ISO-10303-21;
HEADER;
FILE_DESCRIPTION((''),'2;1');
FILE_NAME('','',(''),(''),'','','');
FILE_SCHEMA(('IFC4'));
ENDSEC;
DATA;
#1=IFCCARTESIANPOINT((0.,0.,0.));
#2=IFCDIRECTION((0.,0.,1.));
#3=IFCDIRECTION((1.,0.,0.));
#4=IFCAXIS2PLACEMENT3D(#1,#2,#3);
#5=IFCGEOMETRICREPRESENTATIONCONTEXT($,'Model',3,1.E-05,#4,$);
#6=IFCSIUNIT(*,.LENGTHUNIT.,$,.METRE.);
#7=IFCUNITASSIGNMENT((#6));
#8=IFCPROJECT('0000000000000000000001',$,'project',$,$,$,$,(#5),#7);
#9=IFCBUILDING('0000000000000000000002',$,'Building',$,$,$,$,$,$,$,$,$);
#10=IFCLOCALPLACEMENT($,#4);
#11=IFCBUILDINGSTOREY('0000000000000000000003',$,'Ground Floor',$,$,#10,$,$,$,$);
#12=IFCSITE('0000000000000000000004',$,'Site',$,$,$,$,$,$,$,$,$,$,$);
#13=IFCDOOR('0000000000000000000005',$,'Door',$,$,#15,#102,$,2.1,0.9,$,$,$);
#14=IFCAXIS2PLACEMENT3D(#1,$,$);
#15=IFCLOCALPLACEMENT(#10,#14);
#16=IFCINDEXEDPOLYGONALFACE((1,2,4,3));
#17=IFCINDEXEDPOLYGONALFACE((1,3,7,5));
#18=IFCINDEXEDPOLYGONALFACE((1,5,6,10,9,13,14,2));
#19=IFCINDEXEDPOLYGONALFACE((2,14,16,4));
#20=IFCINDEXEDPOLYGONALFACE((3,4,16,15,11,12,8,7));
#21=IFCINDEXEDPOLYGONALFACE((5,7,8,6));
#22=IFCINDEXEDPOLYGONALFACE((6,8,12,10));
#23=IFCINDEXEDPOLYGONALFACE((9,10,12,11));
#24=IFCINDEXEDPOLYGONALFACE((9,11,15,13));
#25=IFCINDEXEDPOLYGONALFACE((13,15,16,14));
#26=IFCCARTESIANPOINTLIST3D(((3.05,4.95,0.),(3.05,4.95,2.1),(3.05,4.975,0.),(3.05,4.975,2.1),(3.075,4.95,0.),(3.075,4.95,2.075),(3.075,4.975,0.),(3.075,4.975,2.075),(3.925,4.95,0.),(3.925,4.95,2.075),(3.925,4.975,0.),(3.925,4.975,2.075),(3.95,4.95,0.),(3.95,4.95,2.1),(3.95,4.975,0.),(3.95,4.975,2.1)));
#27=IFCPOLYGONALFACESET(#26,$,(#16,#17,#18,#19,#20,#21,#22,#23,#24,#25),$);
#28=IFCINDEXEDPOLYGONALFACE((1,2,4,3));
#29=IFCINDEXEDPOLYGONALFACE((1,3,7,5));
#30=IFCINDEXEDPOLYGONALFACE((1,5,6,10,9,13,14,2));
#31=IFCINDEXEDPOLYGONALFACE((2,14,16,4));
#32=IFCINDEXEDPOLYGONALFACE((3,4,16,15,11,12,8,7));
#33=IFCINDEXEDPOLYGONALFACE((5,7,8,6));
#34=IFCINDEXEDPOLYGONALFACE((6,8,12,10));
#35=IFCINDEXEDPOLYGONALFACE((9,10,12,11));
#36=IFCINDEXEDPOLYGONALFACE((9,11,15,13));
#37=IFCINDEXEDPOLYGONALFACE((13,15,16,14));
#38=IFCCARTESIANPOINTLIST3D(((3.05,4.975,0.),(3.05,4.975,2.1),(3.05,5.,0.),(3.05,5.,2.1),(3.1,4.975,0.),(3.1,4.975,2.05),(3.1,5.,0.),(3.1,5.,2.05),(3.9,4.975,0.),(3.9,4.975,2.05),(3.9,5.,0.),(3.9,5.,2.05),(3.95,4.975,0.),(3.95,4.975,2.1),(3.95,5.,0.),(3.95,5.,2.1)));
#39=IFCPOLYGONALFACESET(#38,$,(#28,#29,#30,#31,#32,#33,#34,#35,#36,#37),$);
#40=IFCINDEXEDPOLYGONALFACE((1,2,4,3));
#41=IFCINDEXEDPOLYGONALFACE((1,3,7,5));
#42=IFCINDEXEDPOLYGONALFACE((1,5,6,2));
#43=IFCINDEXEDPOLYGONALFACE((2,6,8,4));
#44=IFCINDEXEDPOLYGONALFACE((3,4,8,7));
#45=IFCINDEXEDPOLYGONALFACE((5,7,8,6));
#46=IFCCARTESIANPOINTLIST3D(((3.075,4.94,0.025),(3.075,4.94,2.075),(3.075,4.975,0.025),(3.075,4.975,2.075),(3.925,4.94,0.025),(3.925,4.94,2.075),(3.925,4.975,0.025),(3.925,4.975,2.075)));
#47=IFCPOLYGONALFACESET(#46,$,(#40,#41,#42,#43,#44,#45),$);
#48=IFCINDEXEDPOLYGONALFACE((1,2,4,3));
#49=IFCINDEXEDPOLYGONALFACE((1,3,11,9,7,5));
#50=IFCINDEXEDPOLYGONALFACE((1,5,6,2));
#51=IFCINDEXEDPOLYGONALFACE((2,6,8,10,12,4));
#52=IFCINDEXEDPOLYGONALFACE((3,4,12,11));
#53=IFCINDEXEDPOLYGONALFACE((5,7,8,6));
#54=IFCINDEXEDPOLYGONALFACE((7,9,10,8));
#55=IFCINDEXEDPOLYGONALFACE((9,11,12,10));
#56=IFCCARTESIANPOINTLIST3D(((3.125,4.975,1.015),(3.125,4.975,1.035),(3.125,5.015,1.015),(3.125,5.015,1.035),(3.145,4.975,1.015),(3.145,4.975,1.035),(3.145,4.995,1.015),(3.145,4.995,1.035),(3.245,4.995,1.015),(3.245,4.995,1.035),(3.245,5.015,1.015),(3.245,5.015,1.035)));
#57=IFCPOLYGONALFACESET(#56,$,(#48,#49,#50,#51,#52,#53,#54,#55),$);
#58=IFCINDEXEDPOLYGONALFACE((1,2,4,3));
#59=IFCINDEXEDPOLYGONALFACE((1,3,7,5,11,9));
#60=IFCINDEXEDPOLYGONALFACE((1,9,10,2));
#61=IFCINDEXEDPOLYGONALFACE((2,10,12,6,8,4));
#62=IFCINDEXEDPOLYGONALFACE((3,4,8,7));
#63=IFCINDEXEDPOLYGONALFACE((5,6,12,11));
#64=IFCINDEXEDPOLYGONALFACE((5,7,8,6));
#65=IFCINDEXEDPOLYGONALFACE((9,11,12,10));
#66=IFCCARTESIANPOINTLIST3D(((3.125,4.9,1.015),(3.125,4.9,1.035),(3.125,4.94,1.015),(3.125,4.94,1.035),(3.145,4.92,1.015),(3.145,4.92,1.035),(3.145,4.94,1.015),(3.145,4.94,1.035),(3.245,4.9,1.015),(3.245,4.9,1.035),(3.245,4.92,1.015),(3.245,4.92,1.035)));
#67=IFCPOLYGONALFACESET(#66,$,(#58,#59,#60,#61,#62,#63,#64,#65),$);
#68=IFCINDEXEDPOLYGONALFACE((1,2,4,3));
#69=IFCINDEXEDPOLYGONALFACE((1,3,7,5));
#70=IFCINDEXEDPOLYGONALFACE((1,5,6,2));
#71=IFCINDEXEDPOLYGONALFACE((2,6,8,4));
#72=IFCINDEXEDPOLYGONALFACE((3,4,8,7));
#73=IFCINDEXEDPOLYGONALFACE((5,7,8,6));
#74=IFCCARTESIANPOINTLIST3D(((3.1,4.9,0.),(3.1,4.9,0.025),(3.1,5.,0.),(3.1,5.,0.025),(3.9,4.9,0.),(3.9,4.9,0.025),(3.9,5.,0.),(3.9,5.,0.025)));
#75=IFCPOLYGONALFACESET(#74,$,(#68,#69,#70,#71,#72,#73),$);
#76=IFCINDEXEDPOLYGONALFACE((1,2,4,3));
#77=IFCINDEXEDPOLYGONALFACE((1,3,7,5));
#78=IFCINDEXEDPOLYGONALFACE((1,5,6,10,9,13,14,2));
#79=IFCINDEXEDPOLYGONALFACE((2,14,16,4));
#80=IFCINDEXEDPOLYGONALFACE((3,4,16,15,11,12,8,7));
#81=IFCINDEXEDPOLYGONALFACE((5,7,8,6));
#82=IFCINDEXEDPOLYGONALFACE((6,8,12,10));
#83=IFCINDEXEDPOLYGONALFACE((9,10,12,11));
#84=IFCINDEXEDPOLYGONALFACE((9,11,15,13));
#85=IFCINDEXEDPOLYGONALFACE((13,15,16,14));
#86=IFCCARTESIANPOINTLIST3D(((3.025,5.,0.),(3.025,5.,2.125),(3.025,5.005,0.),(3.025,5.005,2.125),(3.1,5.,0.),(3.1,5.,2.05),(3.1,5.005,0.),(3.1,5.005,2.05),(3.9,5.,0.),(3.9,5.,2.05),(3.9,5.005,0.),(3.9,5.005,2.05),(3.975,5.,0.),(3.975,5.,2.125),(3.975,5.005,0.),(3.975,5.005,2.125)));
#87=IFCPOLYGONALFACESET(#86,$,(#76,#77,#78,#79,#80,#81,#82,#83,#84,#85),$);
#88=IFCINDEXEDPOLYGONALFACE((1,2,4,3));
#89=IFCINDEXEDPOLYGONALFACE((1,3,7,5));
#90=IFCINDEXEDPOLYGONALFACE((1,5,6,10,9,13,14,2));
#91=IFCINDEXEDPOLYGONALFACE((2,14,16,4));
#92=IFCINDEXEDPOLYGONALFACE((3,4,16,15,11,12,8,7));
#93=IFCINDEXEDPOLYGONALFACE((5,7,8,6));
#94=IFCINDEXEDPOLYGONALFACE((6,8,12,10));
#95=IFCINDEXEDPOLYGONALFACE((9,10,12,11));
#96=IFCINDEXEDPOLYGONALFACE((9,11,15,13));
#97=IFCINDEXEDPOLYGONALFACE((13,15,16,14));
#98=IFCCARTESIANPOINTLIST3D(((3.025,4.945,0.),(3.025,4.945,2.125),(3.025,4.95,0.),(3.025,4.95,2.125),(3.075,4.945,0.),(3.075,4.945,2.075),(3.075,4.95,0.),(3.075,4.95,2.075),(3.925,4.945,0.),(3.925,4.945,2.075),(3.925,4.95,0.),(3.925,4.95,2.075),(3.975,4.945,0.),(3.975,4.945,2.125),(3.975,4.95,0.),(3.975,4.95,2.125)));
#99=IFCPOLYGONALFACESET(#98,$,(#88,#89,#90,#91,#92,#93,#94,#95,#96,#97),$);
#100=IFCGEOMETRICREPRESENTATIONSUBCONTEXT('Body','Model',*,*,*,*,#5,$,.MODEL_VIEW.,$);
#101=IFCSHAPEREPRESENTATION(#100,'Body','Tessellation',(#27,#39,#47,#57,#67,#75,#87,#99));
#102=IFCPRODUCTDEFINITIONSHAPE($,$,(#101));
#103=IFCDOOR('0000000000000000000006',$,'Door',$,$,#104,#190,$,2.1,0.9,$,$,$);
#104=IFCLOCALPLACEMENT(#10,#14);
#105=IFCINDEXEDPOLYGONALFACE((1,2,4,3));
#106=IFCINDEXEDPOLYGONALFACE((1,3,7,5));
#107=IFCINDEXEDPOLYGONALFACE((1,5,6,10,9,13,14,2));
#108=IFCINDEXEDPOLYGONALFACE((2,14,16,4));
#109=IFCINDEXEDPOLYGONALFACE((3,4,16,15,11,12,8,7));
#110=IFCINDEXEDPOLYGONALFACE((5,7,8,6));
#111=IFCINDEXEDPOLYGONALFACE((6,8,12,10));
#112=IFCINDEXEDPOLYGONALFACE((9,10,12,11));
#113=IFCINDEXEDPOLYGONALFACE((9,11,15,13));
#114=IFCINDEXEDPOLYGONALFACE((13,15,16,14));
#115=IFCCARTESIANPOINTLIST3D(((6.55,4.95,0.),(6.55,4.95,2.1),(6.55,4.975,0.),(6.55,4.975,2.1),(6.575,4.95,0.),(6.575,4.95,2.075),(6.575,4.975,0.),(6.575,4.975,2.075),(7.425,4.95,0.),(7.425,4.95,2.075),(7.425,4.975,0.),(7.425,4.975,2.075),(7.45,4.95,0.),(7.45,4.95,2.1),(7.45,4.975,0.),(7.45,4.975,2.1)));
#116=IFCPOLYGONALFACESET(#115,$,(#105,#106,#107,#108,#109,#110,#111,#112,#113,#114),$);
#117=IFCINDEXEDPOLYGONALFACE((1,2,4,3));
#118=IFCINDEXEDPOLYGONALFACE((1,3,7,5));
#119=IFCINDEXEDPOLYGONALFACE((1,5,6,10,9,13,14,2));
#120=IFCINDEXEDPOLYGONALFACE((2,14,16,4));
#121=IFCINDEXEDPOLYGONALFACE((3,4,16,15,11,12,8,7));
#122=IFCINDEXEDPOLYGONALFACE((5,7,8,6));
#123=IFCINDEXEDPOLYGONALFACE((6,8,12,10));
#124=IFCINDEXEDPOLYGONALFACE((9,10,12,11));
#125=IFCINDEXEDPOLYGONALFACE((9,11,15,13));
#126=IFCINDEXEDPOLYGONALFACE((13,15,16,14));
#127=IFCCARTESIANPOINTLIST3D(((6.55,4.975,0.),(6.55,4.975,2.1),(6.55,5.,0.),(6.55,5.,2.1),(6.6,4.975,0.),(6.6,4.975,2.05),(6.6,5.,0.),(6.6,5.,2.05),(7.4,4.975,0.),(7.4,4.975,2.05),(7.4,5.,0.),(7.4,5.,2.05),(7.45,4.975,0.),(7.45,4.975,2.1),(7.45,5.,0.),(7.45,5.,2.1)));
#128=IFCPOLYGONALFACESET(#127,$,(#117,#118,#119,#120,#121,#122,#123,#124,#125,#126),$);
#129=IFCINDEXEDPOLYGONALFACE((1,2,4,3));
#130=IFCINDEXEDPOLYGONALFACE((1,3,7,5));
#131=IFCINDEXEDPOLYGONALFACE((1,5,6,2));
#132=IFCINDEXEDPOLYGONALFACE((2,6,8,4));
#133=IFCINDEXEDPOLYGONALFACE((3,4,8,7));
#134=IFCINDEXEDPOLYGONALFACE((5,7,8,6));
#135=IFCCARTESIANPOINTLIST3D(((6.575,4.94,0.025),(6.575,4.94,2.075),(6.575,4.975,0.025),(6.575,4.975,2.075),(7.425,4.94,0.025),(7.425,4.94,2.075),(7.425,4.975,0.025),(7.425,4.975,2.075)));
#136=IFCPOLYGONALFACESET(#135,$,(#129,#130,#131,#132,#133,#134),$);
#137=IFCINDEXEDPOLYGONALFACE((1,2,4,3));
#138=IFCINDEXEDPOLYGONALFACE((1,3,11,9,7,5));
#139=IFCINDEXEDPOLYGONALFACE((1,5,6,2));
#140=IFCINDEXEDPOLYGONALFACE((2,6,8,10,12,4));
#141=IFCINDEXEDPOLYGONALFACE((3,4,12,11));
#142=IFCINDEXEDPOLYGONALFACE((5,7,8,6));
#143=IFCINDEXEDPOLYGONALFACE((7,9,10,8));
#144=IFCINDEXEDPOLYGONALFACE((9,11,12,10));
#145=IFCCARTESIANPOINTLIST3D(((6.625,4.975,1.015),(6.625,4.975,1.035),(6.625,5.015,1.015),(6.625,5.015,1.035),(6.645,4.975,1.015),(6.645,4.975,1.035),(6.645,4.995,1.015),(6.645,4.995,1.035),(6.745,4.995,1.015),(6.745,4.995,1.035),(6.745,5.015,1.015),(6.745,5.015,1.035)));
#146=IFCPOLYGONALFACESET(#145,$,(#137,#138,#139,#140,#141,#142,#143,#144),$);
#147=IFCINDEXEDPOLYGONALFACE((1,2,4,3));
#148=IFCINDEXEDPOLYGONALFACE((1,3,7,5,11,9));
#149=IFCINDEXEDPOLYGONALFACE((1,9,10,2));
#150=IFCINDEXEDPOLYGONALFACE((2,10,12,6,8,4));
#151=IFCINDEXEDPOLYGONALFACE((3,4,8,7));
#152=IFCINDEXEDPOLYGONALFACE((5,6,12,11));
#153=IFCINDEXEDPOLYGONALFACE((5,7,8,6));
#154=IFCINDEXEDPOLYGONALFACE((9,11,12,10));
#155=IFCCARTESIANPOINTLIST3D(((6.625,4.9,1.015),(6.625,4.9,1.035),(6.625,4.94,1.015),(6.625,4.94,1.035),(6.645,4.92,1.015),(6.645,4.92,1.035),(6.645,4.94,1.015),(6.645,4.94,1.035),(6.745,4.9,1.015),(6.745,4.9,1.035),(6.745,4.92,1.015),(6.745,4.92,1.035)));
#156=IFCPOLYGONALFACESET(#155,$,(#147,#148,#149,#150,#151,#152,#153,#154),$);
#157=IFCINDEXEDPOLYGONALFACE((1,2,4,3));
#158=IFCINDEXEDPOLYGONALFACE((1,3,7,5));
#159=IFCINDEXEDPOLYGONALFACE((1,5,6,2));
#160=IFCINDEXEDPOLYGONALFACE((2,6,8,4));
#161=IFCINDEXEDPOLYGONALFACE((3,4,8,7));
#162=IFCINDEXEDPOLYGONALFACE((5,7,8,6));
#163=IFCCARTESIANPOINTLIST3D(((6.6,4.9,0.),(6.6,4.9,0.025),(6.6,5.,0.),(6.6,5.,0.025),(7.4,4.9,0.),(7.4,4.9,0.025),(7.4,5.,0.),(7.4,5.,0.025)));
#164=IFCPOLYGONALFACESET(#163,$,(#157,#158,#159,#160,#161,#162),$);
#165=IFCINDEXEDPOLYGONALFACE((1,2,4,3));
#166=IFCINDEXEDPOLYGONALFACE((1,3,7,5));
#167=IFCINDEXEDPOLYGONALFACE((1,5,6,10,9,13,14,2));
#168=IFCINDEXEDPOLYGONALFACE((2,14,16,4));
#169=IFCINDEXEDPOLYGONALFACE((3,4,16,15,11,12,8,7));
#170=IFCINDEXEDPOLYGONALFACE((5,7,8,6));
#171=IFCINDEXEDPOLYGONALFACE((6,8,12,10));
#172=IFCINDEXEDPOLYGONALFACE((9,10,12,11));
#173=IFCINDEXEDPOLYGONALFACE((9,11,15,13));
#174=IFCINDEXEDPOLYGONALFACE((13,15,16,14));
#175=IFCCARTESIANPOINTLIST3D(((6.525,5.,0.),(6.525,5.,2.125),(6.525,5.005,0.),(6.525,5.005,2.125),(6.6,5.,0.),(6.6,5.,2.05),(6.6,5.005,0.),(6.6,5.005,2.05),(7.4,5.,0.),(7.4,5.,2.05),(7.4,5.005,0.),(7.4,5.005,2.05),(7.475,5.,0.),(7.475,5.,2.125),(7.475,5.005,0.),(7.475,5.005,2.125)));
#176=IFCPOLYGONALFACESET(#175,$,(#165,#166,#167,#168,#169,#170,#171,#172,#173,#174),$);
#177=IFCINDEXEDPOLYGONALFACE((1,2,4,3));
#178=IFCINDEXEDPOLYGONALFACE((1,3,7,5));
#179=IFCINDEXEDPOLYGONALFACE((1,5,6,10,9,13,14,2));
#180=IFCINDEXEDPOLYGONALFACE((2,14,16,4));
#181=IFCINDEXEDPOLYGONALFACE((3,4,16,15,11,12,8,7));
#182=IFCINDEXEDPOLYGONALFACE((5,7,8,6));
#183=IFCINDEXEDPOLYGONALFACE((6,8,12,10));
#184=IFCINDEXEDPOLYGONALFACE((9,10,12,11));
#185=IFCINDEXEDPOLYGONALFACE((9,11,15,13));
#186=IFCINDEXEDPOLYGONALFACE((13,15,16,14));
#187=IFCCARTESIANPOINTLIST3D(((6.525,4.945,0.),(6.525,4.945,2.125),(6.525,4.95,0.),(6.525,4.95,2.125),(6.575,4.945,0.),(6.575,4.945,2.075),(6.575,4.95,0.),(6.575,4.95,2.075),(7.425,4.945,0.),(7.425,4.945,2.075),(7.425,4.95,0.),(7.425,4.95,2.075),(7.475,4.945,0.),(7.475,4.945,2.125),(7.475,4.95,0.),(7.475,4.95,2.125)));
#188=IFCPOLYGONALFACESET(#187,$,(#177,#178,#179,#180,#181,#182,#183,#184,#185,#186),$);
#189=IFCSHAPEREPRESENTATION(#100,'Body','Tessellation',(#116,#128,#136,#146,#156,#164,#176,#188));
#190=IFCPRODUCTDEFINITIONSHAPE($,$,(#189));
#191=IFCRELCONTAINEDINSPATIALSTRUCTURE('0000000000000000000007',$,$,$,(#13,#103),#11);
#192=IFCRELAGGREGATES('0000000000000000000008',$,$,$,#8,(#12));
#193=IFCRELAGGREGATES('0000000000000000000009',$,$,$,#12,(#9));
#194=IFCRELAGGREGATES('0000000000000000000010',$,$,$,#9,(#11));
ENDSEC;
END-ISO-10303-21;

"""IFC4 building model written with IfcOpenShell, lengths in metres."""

from ifc_helpers import new_model, si_unit, frame, origin_with_axes, place, context, subcontext, project, spatial, line, indexed_curve, outline, extrude, element, save


model = new_model("IFC4")

# Units and contexts
model_context = context("Model", 3, precision=1e-05, world=origin_with_axes())
body_context = subcontext(model_context, "Body", "Model", "MODEL_VIEW")
ifc_project = project(units=[si_unit("LENGTHUNIT", "METRE")], contexts=[model_context])

# Site, building, storey
site = spatial("IfcSite", under=ifc_project, Name="Site")
building = spatial("IfcBuilding", under=site, Name="Building")
storey_placement = place(None, origin_with_axes())
storey = spatial("IfcBuildingStorey", under=building, at=storey_placement, Name="Ground Floor")

# Doors
door_1_placement = place(storey_placement, frame((3.95, 5.0, 0.0), z_axis=(0.0, 0.0, 1.0), x_axis=(-1.0, 0.0, 0.0)))
element("IfcDoor", 1, at=door_1_placement, inside=storey, Name="Door", OverallHeight=2.1, OverallWidth=0.9, context=body_context, shape_type="SweptSolid", body=[
    extrude(outline(indexed_curve([(0.0, 0.0), (0.0, 2.1), (0.9, 2.1), (0.9, 0.0), (0.875, 0.0), (0.875, 2.075), (0.025, 2.075), (0.025, 0.0)], segments=[line(1, 2, 3, 4, 5, 6, 7, 8, 1)])), frame((0.0, 0.025, 0.0), z_axis=(0.0, -1.0, 0.0), x_axis=(1.0, 0.0, 0.0)), (0.0, 0.0, -1.0), 0.025),
    extrude(outline(indexed_curve([(0.0, 0.0), (0.0, 2.1), (0.9, 2.1), (0.9, 0.0), (0.85, 0.0), (0.85, 2.05), (0.05, 2.05), (0.05, 0.0)], segments=[line(1, 2, 3, 4, 5, 6, 7, 8, 1)])), frame((0.0, 0.0, 0.0), z_axis=(0.0, -1.0, 0.0), x_axis=(1.0, 0.0, 0.0)), (0.0, 0.0, -1.0), 0.025),
    extrude(outline(indexed_curve([(0.0, 0.0), (0.85, 0.0), (0.85, 0.035), (0.0, 0.035)], segments=[line(1, 2, 3, 4, 1)])), frame((0.025, 0.025, 0.025), z_axis=(0.0, 0.0, 1.0), x_axis=(1.0, 0.0, 0.0)), (0.0, 0.0, 1.0), 2.05),
    extrude(outline(indexed_curve([(0.0, 0.0), (0.0, -0.04), (-0.12, -0.04), (-0.12, -0.02), (-0.02, -0.02), (-0.02, 0.0)], segments=[line(1, 2, 3, 4, 5, 6, 1)])), frame((0.825, 0.025, 1.015), z_axis=(0.0, 0.0, 1.0), x_axis=(1.0, 0.0, 0.0)), (0.0, 0.0, 1.0), 0.02),
    extrude(outline(indexed_curve([(0.0, 0.0), (0.0, 0.04), (-0.12, 0.04), (-0.12, 0.02), (-0.02, 0.02), (-0.02, 0.0)], segments=[line(1, 2, 3, 4, 5, 6, 1)])), frame((0.825, 0.06, 1.015), z_axis=(0.0, 0.0, 1.0), x_axis=(1.0, 0.0, 0.0)), (0.0, 0.0, 1.0), 0.02),
    extrude(outline(indexed_curve([(0.0, 0.0), (0.8, 0.0), (0.8, 0.1), (0.0, 0.1)], segments=[line(1, 2, 3, 4, 1)])), frame((0.05, 0.0, 0.0), z_axis=(0.0, 0.0, 1.0), x_axis=(1.0, 0.0, 0.0)), (0.0, 0.0, 1.0), 0.025),
    extrude(outline(indexed_curve([(0.0, 0.0), (0.0, 2.125), (0.95, 2.125), (0.95, 0.0), (0.875, 0.0), (0.875, 2.05), (0.075, 2.05), (0.075, 0.0)], segments=[line(1, 2, 3, 4, 5, 6, 7, 8, 1)])), frame((-0.025, -0.005, 0.0), z_axis=(0.0, -1.0, 0.0), x_axis=(1.0, 0.0, 0.0)), (0.0, 0.0, -1.0), 0.005),
    extrude(outline(indexed_curve([(0.0, 0.0), (0.0, 2.125), (0.95, 2.125), (0.95, 0.0), (0.9, 0.0), (0.9, 2.075), (0.05, 2.075), (0.05, 0.0)], segments=[line(1, 2, 3, 4, 5, 6, 7, 8, 1)])), frame((-0.025, 0.05, 0.0), z_axis=(0.0, -1.0, 0.0), x_axis=(1.0, 0.0, 0.0)), (0.0, 0.0, -1.0), 0.005),
])
door_2_placement = place(storey_placement, frame((7.45, 5.0, 0.0), z_axis=(0.0, 0.0, 1.0), x_axis=(-1.0, 0.0, 0.0)))
element("IfcDoor", 2, at=door_2_placement, inside=storey, Name="Door", OverallHeight=2.1, OverallWidth=0.9, context=body_context, shape_type="SweptSolid", body=[
    extrude(outline(indexed_curve([(0.0, 0.0), (0.0, 2.1), (0.9, 2.1), (0.9, 0.0), (0.875, 0.0), (0.875, 2.075), (0.025, 2.075), (0.025, 0.0)], segments=[line(1, 2, 3, 4, 5, 6, 7, 8, 1)])), frame((0.0, 0.025, 0.0), z_axis=(0.0, -1.0, 0.0), x_axis=(1.0, 0.0, 0.0)), (0.0, 0.0, -1.0), 0.025),
    extrude(outline(indexed_curve([(0.0, 0.0), (0.0, 2.1), (0.9, 2.1), (0.9, 0.0), (0.85, 0.0), (0.85, 2.05), (0.05, 2.05), (0.05, 0.0)], segments=[line(1, 2, 3, 4, 5, 6, 7, 8, 1)])), frame((0.0, 0.0, 0.0), z_axis=(0.0, -1.0, 0.0), x_axis=(1.0, 0.0, 0.0)), (0.0, 0.0, -1.0), 0.025),
    extrude(outline(indexed_curve([(0.0, 0.0), (0.85, 0.0), (0.85, 0.035), (0.0, 0.035)], segments=[line(1, 2, 3, 4, 1)])), frame((0.025, 0.025, 0.025), z_axis=(0.0, 0.0, 1.0), x_axis=(1.0, 0.0, 0.0)), (0.0, 0.0, 1.0), 2.05),
    extrude(outline(indexed_curve([(0.0, 0.0), (0.0, -0.04), (-0.12, -0.04), (-0.12, -0.02), (-0.02, -0.02), (-0.02, 0.0)], segments=[line(1, 2, 3, 4, 5, 6, 1)])), frame((0.825, 0.025, 1.015), z_axis=(0.0, 0.0, 1.0), x_axis=(1.0, 0.0, 0.0)), (0.0, 0.0, 1.0), 0.02),
    extrude(outline(indexed_curve([(0.0, 0.0), (0.0, 0.04), (-0.12, 0.04), (-0.12, 0.02), (-0.02, 0.02), (-0.02, 0.0)], segments=[line(1, 2, 3, 4, 5, 6, 1)])), frame((0.825, 0.06, 1.015), z_axis=(0.0, 0.0, 1.0), x_axis=(1.0, 0.0, 0.0)), (0.0, 0.0, 1.0), 0.02),
    extrude(outline(indexed_curve([(0.0, 0.0), (0.8, 0.0), (0.8, 0.1), (0.0, 0.1)], segments=[line(1, 2, 3, 4, 1)])), frame((0.05, 0.0, 0.0), z_axis=(0.0, 0.0, 1.0), x_axis=(1.0, 0.0, 0.0)), (0.0, 0.0, 1.0), 0.025),
    extrude(outline(indexed_curve([(0.0, 0.0), (0.0, 2.125), (0.95, 2.125), (0.95, 0.0), (0.875, 0.0), (0.875, 2.05), (0.075, 2.05), (0.075, 0.0)], segments=[line(1, 2, 3, 4, 5, 6, 7, 8, 1)])), frame((-0.025, -0.005, 0.0), z_axis=(0.0, -1.0, 0.0), x_axis=(1.0, 0.0, 0.0)), (0.0, 0.0, -1.0), 0.005),
    extrude(outline(indexed_curve([(0.0, 0.0), (0.0, 2.125), (0.95, 2.125), (0.95, 0.0), (0.9, 0.0), (0.9, 2.075), (0.05, 2.075), (0.05, 0.0)], segments=[line(1, 2, 3, 4, 5, 6, 7, 8, 1)])), frame((-0.025, 0.05, 0.0), z_axis=(0.0, -1.0, 0.0), x_axis=(1.0, 0.0, 0.0)), (0.0, 0.0, -1.0), 0.005),
])

save(model, "model.ifc")
